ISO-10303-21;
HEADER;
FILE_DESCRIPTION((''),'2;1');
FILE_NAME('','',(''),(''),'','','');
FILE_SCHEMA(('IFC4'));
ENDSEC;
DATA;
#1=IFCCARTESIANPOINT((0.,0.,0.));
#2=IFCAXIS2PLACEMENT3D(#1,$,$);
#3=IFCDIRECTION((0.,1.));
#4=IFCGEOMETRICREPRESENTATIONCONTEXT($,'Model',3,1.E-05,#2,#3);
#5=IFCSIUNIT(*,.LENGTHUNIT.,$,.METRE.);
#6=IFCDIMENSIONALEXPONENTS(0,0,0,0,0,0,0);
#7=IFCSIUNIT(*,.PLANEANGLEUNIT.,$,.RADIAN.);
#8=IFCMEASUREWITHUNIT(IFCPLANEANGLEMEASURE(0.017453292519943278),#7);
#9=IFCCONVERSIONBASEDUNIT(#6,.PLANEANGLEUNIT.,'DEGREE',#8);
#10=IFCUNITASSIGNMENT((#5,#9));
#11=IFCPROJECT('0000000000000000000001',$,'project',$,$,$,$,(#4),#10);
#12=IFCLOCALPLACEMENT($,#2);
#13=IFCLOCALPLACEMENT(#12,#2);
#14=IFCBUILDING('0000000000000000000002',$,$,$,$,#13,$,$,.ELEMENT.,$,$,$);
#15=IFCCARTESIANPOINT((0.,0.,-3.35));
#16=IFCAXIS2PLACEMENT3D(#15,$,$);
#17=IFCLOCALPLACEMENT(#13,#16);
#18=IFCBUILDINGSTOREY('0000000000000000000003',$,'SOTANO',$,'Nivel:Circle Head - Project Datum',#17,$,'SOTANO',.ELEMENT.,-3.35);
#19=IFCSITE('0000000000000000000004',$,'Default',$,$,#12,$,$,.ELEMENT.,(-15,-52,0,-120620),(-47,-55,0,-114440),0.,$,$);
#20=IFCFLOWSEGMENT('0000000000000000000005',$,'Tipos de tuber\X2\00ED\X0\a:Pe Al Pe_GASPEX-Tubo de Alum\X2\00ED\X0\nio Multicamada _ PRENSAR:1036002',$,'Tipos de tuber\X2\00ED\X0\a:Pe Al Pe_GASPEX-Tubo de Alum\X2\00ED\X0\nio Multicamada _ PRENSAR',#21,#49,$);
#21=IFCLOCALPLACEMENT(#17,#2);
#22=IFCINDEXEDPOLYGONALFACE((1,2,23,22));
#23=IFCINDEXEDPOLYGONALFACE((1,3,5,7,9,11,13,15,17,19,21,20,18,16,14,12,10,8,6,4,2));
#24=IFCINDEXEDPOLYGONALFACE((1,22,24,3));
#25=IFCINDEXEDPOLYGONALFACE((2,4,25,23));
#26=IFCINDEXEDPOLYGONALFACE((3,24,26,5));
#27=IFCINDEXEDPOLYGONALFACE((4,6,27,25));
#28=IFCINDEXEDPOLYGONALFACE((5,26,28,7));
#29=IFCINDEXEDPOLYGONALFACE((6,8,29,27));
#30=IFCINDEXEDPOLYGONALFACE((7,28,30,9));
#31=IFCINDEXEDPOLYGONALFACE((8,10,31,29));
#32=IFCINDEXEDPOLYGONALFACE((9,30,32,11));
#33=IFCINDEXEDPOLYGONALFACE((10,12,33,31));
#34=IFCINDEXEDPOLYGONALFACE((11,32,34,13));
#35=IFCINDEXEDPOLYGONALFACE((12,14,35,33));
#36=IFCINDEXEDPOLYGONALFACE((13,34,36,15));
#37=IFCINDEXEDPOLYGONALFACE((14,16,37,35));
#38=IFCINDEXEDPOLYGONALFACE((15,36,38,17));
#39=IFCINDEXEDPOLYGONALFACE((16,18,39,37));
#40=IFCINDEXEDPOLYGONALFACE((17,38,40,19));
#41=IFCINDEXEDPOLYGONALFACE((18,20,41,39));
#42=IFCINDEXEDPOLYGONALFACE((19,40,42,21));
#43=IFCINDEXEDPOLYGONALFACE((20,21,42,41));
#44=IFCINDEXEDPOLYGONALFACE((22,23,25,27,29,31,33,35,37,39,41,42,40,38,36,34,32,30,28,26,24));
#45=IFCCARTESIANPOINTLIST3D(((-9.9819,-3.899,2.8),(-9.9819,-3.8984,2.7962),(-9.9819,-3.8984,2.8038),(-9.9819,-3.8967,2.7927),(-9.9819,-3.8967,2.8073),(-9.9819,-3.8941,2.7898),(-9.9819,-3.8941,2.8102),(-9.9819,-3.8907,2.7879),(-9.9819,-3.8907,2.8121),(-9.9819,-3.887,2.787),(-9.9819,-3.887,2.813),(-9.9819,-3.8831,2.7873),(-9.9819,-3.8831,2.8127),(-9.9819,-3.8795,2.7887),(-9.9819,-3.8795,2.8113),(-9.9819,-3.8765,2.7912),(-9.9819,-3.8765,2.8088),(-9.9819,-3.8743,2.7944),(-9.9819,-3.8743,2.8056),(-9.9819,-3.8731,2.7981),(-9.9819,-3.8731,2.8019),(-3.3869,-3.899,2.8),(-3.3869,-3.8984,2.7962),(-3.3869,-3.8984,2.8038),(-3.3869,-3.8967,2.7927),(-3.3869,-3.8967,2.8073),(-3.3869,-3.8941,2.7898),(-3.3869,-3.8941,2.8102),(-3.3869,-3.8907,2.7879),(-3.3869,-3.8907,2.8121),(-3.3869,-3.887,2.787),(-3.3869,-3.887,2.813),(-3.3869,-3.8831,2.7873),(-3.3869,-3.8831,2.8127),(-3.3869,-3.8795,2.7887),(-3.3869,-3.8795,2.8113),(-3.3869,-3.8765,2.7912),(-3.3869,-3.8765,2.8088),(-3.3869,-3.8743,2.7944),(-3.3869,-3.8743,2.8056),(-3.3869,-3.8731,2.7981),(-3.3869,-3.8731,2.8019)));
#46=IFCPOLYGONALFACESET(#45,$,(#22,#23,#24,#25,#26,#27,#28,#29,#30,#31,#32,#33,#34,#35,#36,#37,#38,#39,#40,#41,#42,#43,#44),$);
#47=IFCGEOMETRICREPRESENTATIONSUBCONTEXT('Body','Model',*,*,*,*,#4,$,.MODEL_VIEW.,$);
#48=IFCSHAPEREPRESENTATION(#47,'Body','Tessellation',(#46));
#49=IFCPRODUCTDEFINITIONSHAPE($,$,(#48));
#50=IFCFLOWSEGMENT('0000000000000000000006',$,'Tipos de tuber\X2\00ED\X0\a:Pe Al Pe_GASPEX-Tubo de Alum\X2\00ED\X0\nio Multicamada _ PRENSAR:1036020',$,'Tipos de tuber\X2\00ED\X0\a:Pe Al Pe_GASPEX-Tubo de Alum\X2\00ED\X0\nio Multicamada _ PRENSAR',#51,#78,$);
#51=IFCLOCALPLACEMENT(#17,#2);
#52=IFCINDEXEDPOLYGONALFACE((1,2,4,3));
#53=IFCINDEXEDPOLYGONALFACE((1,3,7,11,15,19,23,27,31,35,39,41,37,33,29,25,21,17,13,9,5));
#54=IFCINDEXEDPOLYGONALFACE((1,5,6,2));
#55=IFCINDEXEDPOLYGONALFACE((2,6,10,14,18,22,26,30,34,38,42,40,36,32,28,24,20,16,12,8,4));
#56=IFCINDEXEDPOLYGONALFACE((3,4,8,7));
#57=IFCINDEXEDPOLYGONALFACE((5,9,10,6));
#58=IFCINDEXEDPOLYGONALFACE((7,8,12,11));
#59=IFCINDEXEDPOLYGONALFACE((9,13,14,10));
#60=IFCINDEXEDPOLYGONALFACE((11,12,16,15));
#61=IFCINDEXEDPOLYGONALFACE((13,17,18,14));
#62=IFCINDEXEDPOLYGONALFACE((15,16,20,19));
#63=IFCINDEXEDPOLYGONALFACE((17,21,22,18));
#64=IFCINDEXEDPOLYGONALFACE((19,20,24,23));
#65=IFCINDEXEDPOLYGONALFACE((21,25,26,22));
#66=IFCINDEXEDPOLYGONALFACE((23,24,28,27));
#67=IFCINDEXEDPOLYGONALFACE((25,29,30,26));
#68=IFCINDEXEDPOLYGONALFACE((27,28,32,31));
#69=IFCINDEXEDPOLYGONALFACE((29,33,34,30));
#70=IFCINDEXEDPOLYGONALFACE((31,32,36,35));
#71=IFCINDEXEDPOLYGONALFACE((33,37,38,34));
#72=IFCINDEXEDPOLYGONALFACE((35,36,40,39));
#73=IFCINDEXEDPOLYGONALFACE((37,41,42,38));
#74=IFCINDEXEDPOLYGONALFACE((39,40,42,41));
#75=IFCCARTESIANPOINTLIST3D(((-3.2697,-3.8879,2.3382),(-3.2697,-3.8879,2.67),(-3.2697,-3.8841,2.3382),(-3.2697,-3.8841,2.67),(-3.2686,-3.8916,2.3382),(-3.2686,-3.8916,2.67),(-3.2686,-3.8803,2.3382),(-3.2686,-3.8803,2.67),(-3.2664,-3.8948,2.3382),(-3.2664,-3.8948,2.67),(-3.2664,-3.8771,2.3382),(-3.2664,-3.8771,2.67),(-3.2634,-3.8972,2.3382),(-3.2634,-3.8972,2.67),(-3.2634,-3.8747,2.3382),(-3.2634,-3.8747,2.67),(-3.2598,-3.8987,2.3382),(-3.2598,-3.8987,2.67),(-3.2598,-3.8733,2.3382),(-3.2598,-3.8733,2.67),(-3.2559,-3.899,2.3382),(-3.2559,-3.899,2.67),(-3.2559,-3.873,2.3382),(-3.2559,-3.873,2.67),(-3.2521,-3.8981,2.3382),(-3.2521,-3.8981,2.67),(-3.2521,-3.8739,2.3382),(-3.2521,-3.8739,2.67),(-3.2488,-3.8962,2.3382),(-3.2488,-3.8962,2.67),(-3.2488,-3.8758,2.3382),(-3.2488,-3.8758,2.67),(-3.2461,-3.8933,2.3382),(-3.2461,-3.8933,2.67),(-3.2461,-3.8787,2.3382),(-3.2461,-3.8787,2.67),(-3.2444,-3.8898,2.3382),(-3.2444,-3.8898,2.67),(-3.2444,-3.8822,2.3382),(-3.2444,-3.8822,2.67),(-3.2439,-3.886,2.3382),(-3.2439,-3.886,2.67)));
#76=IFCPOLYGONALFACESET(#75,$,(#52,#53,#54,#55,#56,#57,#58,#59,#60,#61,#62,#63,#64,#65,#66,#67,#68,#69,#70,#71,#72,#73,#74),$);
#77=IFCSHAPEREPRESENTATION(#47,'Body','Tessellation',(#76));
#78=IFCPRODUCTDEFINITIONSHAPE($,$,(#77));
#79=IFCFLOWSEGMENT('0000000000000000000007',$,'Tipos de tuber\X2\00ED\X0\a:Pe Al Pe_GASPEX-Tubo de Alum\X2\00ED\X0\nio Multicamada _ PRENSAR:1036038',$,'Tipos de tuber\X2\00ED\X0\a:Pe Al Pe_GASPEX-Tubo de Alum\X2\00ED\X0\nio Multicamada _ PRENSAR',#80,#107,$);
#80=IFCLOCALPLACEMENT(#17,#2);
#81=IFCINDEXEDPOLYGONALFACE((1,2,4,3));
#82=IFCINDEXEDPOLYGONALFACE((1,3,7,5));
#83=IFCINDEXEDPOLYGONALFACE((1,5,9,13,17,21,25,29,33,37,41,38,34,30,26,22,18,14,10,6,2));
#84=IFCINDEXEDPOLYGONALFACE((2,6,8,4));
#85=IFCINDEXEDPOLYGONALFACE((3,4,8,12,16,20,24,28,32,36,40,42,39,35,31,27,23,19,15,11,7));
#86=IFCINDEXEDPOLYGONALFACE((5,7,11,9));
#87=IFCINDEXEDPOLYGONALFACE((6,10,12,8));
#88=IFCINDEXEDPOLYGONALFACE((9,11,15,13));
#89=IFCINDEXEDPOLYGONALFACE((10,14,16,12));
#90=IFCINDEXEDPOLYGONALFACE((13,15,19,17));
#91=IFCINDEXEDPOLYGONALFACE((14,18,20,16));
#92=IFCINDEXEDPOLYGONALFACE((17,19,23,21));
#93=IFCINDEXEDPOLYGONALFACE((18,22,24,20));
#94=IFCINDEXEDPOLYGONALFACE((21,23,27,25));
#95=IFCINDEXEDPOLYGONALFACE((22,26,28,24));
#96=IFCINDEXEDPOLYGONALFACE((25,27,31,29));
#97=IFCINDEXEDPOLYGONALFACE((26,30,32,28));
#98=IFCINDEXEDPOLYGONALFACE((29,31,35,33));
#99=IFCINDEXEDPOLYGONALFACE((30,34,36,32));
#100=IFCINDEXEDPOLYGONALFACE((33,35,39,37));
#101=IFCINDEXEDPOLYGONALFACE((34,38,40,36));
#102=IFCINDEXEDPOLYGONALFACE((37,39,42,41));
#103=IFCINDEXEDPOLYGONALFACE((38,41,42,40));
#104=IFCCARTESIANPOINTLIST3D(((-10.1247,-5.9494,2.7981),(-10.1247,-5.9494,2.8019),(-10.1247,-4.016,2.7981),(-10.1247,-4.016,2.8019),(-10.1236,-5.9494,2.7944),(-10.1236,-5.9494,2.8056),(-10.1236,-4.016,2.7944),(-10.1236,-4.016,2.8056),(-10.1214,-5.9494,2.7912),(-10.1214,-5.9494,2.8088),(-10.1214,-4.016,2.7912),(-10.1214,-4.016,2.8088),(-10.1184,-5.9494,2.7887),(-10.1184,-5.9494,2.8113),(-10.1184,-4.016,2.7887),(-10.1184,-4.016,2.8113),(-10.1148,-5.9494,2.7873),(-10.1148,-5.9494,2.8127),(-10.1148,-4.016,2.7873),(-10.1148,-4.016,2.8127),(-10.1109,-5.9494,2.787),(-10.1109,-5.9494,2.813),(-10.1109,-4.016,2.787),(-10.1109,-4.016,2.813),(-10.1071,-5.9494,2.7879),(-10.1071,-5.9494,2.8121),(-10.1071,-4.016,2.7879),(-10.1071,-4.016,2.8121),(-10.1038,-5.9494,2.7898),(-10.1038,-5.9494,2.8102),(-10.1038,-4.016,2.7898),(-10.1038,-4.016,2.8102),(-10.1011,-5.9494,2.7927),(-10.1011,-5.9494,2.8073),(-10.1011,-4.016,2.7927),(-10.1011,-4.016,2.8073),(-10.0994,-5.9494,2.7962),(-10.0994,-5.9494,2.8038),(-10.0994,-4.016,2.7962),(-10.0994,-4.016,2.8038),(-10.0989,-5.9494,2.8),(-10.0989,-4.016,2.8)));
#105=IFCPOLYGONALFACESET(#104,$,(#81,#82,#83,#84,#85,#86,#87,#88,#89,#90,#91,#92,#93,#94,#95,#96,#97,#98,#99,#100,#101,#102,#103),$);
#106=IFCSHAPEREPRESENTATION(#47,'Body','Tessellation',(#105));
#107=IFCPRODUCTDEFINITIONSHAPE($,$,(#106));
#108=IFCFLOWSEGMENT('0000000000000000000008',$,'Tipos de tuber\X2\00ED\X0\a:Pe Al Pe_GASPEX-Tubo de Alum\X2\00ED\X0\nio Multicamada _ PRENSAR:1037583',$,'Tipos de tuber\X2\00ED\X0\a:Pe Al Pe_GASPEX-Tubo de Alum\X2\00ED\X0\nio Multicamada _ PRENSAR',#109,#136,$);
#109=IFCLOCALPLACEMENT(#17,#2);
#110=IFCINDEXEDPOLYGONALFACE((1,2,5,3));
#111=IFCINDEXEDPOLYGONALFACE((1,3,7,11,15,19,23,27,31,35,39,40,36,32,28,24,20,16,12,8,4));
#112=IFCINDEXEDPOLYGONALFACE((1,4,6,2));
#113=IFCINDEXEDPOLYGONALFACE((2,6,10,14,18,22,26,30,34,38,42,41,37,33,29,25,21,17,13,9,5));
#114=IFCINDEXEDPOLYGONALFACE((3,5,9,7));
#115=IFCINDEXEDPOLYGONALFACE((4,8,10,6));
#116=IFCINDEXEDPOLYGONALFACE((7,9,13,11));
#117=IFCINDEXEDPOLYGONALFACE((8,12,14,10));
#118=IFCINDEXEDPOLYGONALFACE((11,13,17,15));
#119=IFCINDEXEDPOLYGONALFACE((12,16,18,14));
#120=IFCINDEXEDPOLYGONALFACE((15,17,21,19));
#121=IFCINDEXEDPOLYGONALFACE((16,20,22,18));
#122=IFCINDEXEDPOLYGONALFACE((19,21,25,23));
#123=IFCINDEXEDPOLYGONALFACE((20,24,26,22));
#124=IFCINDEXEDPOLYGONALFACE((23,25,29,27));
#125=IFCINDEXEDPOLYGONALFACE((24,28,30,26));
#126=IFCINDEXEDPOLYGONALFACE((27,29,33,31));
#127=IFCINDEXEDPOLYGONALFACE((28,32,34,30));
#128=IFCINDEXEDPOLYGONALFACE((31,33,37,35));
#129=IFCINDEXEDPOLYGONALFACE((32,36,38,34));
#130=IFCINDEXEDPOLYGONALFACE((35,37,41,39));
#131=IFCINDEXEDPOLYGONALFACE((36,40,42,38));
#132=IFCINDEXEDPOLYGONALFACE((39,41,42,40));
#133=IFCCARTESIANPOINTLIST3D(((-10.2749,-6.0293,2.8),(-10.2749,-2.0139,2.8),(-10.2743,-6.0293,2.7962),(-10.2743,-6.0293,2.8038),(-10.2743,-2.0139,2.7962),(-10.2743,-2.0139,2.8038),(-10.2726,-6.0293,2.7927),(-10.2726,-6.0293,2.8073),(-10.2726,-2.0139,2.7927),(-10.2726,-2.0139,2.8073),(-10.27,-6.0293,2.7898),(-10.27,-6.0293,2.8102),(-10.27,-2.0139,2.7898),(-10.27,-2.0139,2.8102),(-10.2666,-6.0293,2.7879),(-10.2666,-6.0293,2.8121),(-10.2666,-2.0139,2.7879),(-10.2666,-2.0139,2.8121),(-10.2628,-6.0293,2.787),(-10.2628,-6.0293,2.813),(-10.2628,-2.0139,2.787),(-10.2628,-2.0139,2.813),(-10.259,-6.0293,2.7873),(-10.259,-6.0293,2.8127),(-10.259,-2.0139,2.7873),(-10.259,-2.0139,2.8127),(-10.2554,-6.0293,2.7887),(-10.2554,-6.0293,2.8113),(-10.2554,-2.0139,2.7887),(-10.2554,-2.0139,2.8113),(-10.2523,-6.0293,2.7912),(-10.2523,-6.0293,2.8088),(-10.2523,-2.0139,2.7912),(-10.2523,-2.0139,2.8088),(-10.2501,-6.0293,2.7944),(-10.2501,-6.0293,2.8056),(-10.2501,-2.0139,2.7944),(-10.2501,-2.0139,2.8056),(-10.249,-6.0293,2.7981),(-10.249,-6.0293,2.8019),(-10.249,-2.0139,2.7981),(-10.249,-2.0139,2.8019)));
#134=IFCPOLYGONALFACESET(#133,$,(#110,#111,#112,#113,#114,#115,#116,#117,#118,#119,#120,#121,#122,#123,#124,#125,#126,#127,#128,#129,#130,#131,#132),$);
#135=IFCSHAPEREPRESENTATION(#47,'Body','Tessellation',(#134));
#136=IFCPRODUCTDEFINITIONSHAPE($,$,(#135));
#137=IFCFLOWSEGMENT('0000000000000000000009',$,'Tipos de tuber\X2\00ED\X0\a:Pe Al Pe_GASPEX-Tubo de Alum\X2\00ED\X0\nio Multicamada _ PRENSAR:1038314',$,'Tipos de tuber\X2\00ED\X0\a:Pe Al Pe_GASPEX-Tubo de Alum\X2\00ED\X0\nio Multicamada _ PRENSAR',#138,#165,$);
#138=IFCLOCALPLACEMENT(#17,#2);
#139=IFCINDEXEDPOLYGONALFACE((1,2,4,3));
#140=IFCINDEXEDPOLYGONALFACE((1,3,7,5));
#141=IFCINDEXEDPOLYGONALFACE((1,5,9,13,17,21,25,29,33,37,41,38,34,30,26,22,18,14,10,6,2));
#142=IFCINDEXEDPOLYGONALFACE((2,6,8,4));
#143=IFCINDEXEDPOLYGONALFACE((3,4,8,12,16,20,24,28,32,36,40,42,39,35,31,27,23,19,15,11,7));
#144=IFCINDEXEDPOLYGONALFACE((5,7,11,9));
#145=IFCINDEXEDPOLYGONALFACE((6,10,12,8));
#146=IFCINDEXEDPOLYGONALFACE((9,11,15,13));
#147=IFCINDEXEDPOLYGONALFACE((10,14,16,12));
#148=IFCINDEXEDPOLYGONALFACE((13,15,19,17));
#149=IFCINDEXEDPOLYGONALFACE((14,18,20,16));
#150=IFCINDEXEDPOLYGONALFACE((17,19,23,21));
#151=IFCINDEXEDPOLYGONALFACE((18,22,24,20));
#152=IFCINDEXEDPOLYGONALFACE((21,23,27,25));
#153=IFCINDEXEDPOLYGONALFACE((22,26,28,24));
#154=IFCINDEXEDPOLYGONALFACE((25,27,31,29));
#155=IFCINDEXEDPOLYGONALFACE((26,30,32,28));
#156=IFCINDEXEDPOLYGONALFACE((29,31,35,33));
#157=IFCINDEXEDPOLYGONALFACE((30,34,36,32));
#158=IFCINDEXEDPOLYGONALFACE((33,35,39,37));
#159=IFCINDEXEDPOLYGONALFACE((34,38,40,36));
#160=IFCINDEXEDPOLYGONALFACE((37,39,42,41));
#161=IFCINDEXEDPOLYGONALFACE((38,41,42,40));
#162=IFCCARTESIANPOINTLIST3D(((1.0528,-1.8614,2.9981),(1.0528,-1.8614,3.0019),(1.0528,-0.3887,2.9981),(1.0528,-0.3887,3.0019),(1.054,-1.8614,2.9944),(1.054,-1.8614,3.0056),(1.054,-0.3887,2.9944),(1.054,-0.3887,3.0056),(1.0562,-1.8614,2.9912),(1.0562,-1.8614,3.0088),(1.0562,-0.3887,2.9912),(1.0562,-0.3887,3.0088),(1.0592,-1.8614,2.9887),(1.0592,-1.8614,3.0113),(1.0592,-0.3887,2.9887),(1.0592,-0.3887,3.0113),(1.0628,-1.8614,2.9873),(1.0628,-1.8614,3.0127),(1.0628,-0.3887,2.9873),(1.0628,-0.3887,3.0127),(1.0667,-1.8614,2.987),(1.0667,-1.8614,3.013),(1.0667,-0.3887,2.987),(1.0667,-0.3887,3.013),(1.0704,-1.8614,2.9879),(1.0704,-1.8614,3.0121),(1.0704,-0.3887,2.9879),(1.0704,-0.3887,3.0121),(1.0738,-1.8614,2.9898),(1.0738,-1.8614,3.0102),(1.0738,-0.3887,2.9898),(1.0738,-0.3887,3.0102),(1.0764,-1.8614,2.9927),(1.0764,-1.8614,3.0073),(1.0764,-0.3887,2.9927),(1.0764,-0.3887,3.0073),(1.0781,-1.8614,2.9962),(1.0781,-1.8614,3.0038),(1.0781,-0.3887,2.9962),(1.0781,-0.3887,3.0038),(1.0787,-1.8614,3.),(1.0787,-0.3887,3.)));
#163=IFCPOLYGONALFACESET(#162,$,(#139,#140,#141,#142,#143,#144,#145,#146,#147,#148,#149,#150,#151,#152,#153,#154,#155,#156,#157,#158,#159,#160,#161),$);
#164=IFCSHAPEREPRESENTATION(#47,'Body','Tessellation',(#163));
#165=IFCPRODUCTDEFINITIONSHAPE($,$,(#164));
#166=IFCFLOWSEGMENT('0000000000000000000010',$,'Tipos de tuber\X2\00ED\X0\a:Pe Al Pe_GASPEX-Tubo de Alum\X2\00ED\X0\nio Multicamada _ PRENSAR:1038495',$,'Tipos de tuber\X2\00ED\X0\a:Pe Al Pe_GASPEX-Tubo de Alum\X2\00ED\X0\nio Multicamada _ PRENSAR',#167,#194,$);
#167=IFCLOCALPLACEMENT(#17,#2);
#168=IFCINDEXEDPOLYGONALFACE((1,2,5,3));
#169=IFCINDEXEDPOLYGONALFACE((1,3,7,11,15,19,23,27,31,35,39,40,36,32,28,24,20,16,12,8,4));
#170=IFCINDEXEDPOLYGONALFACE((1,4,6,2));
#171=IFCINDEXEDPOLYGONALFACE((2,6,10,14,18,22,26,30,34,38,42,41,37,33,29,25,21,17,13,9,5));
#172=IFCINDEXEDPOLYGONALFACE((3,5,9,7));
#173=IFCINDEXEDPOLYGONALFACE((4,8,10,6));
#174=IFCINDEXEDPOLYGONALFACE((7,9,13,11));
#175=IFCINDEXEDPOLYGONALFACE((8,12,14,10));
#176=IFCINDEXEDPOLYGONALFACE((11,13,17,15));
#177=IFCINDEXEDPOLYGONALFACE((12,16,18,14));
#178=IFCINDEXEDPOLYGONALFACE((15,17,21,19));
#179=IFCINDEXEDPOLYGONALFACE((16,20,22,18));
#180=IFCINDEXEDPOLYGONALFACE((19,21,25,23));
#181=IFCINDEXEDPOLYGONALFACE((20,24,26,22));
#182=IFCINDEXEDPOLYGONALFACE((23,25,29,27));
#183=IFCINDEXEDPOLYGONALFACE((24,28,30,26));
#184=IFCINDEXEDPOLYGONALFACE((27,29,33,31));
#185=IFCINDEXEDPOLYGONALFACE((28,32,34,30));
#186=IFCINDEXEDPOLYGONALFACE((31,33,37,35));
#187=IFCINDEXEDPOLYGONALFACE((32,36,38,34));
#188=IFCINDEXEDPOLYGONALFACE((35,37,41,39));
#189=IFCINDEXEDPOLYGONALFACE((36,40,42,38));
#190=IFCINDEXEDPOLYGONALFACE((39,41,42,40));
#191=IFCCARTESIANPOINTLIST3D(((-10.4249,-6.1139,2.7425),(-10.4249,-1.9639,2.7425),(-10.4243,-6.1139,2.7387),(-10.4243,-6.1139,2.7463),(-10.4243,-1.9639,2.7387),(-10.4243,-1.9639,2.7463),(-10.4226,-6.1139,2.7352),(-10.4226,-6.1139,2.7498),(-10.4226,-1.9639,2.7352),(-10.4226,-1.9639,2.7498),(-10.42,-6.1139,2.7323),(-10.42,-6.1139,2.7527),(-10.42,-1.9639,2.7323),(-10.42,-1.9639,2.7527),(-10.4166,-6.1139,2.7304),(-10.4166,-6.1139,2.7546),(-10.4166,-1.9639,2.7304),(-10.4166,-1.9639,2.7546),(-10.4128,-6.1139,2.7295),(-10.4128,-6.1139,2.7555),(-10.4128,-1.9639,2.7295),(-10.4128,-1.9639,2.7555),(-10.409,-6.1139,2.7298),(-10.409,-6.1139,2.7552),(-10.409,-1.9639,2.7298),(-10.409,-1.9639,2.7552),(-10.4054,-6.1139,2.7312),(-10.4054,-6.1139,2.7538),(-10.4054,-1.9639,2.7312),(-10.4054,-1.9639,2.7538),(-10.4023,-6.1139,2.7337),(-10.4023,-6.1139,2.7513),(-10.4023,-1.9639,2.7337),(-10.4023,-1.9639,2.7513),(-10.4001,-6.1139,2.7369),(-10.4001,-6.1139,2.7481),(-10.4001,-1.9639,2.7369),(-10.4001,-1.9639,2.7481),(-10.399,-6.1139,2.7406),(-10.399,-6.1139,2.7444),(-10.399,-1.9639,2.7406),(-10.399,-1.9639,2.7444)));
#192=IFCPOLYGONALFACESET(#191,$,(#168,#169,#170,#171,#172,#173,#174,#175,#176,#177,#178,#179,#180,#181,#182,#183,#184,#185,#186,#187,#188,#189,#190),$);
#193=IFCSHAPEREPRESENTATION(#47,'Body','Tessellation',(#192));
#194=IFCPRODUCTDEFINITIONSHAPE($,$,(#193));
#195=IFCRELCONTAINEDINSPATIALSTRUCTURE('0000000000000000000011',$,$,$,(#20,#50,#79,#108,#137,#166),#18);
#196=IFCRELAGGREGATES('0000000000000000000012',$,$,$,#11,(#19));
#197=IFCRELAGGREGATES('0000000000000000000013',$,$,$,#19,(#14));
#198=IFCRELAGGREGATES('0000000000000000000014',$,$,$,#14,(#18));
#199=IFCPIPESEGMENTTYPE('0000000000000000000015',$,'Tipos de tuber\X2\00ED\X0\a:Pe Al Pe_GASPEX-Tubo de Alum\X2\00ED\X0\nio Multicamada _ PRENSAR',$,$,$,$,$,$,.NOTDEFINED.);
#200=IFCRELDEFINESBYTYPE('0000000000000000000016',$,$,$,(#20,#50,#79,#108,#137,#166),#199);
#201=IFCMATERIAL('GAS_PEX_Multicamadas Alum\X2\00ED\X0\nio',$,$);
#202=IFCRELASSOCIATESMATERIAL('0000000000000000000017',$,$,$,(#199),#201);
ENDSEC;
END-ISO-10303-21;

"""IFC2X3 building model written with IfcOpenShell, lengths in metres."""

from ifc_helpers import new_model, entity, si_unit, converted_unit, direction, frame, frame_2d, origin, origin_2d_with_axis, place, context, subcontext, project, spatial, circle, extrude, material, type_object, element, save


model = new_model("IFC2X3")

# Units and contexts
model_context = context("Model", 3, precision=1e-05, world=origin(), true_north=direction((0.0, 1.0)))
body_context = subcontext(model_context, "Body", "Model", "MODEL_VIEW")
ifc_project = project(units=[si_unit("LENGTHUNIT", "METRE"), converted_unit("PLANEANGLEUNIT", "DEGREE", entity("IfcPlaneAngleMeasure", 0.017453292519943278), si_unit("PLANEANGLEUNIT", "RADIAN"), dimensions=[0, 0, 0, 0, 0, 0, 0])], contexts=[model_context])

# Site, building, storey
site_placement = place(None, origin())
site = spatial("IfcSite", under=ifc_project, at=site_placement, Name="Default", CompositionType="ELEMENT", RefLatitude=(-15, -52, 0, -120620), RefLongitude=(-47, -55, 0, -114440), RefElevation=0.0)
building_placement = place(site_placement, origin())
building = spatial("IfcBuilding", under=site, at=building_placement, CompositionType="ELEMENT")
storey_placement = place(building_placement, frame((0.0, 0.0, -3.35)))
storey = spatial("IfcBuildingStorey", under=building, at=storey_placement, Name="SOTANO", ObjectType="Nivel:Circle Head - Project Datum", LongName="SOTANO", CompositionType="ELEMENT", Elevation=-3.35)

# Flow segments
ifc_material = material(Name="GAS_PEX_Multicamadas Alumínio")
pipe_segment_type_1 = type_object("IfcPipeSegmentType", Name="Tipos de tubería:Pe Al Pe_GASPEX-Tubo de Alumínio Multicamada _ PRENSAR", PredefinedType="NOTDEFINED", material=ifc_material)
flow_segment_1_placement = place(storey_placement, origin())
element("IfcFlowSegment", 1, at=flow_segment_1_placement, inside=storey, type_object=pipe_segment_type_1, Name="Tipos de tubería:Pe Al Pe_GASPEX-Tubo de Alumínio Multicamada _ PRENSAR:1036002", ObjectType="Tipos de tubería:Pe Al Pe_GASPEX-Tubo de Alumínio Multicamada _ PRENSAR", context=body_context, shape_type="SweptSolid", body=[
    extrude(circle(Radius=0.013, at=origin_2d_with_axis()), frame((-9.9819, -3.886, 2.8), z_axis=(1.0, 0.0, 0.0), x_axis=(0.0, -1.0, 0.0)), (0.0, 0.0, 1.0), 6.595),
])
flow_segment_2_placement = place(storey_placement, origin())
element("IfcFlowSegment", 2, at=flow_segment_2_placement, inside=storey, type_object=pipe_segment_type_1, Name="Tipos de tubería:Pe Al Pe_GASPEX-Tubo de Alumínio Multicamada _ PRENSAR:1036020", ObjectType="Tipos de tubería:Pe Al Pe_GASPEX-Tubo de Alumínio Multicamada _ PRENSAR", context=body_context, shape_type="SweptSolid", body=[
    extrude(circle(Radius=0.013, at=frame_2d((0.0, 0.0), x_axis=(1.0, 0.0))), frame((-3.2569, -3.886, 2.3382)), (0.0, 0.0, 1.0), 0.3318),
])
flow_segment_3_placement = place(storey_placement, origin())
element("IfcFlowSegment", 3, at=flow_segment_3_placement, inside=storey, type_object=pipe_segment_type_1, Name="Tipos de tubería:Pe Al Pe_GASPEX-Tubo de Alumínio Multicamada _ PRENSAR:1036038", ObjectType="Tipos de tubería:Pe Al Pe_GASPEX-Tubo de Alumínio Multicamada _ PRENSAR", context=body_context, shape_type="SweptSolid", body=[
    extrude(circle(Radius=0.013, at=origin_2d_with_axis()), frame((-10.1119, -5.9494, 2.8), z_axis=(0.0, 1.0, 0.0), x_axis=(1.0, 0.0, 0.0)), (0.0, 0.0, 1.0), 1.9334),
])
flow_segment_4_placement = place(storey_placement, origin())
element("IfcFlowSegment", 4, at=flow_segment_4_placement, inside=storey, type_object=pipe_segment_type_1, Name="Tipos de tubería:Pe Al Pe_GASPEX-Tubo de Alumínio Multicamada _ PRENSAR:1037583", ObjectType="Tipos de tubería:Pe Al Pe_GASPEX-Tubo de Alumínio Multicamada _ PRENSAR", context=body_context, shape_type="SweptSolid", body=[
    extrude(circle(Radius=0.013, at=frame_2d((0.0, 0.0), x_axis=(1.0, 0.0))), frame((-10.2619, -6.0293, 2.8), z_axis=(0.0, 1.0, 0.0), x_axis=(-1.0, 0.0, 0.0)), (0.0, 0.0, 1.0), 4.0154),
])
flow_segment_5_placement = place(storey_placement, origin())
element("IfcFlowSegment", 5, at=flow_segment_5_placement, inside=storey, type_object=pipe_segment_type_1, Name="Tipos de tubería:Pe Al Pe_GASPEX-Tubo de Alumínio Multicamada _ PRENSAR:1038314", ObjectType="Tipos de tubería:Pe Al Pe_GASPEX-Tubo de Alumínio Multicamada _ PRENSAR", context=body_context, shape_type="SweptSolid", body=[
    extrude(circle(Radius=0.013, at=origin_2d_with_axis()), frame((1.0657, -1.8614, 3.0), z_axis=(0.0, 1.0, 0.0), x_axis=(1.0, 0.0, 0.0)), (0.0, 0.0, 1.0), 1.4727),
])
flow_segment_6_placement = place(storey_placement, origin())
element("IfcFlowSegment", 6, at=flow_segment_6_placement, inside=storey, type_object=pipe_segment_type_1, Name="Tipos de tubería:Pe Al Pe_GASPEX-Tubo de Alumínio Multicamada _ PRENSAR:1038495", ObjectType="Tipos de tubería:Pe Al Pe_GASPEX-Tubo de Alumínio Multicamada _ PRENSAR", context=body_context, shape_type="SweptSolid", body=[
    extrude(circle(Radius=0.013, at=frame_2d((0.0, 0.0), x_axis=(1.0, 0.0))), frame((-10.4119, -6.1139, 2.7425), z_axis=(0.0, 1.0, 0.0), x_axis=(-1.0, 0.0, 0.0)), (0.0, 0.0, 1.0), 4.15),
])

save(model, "model.ifc")
